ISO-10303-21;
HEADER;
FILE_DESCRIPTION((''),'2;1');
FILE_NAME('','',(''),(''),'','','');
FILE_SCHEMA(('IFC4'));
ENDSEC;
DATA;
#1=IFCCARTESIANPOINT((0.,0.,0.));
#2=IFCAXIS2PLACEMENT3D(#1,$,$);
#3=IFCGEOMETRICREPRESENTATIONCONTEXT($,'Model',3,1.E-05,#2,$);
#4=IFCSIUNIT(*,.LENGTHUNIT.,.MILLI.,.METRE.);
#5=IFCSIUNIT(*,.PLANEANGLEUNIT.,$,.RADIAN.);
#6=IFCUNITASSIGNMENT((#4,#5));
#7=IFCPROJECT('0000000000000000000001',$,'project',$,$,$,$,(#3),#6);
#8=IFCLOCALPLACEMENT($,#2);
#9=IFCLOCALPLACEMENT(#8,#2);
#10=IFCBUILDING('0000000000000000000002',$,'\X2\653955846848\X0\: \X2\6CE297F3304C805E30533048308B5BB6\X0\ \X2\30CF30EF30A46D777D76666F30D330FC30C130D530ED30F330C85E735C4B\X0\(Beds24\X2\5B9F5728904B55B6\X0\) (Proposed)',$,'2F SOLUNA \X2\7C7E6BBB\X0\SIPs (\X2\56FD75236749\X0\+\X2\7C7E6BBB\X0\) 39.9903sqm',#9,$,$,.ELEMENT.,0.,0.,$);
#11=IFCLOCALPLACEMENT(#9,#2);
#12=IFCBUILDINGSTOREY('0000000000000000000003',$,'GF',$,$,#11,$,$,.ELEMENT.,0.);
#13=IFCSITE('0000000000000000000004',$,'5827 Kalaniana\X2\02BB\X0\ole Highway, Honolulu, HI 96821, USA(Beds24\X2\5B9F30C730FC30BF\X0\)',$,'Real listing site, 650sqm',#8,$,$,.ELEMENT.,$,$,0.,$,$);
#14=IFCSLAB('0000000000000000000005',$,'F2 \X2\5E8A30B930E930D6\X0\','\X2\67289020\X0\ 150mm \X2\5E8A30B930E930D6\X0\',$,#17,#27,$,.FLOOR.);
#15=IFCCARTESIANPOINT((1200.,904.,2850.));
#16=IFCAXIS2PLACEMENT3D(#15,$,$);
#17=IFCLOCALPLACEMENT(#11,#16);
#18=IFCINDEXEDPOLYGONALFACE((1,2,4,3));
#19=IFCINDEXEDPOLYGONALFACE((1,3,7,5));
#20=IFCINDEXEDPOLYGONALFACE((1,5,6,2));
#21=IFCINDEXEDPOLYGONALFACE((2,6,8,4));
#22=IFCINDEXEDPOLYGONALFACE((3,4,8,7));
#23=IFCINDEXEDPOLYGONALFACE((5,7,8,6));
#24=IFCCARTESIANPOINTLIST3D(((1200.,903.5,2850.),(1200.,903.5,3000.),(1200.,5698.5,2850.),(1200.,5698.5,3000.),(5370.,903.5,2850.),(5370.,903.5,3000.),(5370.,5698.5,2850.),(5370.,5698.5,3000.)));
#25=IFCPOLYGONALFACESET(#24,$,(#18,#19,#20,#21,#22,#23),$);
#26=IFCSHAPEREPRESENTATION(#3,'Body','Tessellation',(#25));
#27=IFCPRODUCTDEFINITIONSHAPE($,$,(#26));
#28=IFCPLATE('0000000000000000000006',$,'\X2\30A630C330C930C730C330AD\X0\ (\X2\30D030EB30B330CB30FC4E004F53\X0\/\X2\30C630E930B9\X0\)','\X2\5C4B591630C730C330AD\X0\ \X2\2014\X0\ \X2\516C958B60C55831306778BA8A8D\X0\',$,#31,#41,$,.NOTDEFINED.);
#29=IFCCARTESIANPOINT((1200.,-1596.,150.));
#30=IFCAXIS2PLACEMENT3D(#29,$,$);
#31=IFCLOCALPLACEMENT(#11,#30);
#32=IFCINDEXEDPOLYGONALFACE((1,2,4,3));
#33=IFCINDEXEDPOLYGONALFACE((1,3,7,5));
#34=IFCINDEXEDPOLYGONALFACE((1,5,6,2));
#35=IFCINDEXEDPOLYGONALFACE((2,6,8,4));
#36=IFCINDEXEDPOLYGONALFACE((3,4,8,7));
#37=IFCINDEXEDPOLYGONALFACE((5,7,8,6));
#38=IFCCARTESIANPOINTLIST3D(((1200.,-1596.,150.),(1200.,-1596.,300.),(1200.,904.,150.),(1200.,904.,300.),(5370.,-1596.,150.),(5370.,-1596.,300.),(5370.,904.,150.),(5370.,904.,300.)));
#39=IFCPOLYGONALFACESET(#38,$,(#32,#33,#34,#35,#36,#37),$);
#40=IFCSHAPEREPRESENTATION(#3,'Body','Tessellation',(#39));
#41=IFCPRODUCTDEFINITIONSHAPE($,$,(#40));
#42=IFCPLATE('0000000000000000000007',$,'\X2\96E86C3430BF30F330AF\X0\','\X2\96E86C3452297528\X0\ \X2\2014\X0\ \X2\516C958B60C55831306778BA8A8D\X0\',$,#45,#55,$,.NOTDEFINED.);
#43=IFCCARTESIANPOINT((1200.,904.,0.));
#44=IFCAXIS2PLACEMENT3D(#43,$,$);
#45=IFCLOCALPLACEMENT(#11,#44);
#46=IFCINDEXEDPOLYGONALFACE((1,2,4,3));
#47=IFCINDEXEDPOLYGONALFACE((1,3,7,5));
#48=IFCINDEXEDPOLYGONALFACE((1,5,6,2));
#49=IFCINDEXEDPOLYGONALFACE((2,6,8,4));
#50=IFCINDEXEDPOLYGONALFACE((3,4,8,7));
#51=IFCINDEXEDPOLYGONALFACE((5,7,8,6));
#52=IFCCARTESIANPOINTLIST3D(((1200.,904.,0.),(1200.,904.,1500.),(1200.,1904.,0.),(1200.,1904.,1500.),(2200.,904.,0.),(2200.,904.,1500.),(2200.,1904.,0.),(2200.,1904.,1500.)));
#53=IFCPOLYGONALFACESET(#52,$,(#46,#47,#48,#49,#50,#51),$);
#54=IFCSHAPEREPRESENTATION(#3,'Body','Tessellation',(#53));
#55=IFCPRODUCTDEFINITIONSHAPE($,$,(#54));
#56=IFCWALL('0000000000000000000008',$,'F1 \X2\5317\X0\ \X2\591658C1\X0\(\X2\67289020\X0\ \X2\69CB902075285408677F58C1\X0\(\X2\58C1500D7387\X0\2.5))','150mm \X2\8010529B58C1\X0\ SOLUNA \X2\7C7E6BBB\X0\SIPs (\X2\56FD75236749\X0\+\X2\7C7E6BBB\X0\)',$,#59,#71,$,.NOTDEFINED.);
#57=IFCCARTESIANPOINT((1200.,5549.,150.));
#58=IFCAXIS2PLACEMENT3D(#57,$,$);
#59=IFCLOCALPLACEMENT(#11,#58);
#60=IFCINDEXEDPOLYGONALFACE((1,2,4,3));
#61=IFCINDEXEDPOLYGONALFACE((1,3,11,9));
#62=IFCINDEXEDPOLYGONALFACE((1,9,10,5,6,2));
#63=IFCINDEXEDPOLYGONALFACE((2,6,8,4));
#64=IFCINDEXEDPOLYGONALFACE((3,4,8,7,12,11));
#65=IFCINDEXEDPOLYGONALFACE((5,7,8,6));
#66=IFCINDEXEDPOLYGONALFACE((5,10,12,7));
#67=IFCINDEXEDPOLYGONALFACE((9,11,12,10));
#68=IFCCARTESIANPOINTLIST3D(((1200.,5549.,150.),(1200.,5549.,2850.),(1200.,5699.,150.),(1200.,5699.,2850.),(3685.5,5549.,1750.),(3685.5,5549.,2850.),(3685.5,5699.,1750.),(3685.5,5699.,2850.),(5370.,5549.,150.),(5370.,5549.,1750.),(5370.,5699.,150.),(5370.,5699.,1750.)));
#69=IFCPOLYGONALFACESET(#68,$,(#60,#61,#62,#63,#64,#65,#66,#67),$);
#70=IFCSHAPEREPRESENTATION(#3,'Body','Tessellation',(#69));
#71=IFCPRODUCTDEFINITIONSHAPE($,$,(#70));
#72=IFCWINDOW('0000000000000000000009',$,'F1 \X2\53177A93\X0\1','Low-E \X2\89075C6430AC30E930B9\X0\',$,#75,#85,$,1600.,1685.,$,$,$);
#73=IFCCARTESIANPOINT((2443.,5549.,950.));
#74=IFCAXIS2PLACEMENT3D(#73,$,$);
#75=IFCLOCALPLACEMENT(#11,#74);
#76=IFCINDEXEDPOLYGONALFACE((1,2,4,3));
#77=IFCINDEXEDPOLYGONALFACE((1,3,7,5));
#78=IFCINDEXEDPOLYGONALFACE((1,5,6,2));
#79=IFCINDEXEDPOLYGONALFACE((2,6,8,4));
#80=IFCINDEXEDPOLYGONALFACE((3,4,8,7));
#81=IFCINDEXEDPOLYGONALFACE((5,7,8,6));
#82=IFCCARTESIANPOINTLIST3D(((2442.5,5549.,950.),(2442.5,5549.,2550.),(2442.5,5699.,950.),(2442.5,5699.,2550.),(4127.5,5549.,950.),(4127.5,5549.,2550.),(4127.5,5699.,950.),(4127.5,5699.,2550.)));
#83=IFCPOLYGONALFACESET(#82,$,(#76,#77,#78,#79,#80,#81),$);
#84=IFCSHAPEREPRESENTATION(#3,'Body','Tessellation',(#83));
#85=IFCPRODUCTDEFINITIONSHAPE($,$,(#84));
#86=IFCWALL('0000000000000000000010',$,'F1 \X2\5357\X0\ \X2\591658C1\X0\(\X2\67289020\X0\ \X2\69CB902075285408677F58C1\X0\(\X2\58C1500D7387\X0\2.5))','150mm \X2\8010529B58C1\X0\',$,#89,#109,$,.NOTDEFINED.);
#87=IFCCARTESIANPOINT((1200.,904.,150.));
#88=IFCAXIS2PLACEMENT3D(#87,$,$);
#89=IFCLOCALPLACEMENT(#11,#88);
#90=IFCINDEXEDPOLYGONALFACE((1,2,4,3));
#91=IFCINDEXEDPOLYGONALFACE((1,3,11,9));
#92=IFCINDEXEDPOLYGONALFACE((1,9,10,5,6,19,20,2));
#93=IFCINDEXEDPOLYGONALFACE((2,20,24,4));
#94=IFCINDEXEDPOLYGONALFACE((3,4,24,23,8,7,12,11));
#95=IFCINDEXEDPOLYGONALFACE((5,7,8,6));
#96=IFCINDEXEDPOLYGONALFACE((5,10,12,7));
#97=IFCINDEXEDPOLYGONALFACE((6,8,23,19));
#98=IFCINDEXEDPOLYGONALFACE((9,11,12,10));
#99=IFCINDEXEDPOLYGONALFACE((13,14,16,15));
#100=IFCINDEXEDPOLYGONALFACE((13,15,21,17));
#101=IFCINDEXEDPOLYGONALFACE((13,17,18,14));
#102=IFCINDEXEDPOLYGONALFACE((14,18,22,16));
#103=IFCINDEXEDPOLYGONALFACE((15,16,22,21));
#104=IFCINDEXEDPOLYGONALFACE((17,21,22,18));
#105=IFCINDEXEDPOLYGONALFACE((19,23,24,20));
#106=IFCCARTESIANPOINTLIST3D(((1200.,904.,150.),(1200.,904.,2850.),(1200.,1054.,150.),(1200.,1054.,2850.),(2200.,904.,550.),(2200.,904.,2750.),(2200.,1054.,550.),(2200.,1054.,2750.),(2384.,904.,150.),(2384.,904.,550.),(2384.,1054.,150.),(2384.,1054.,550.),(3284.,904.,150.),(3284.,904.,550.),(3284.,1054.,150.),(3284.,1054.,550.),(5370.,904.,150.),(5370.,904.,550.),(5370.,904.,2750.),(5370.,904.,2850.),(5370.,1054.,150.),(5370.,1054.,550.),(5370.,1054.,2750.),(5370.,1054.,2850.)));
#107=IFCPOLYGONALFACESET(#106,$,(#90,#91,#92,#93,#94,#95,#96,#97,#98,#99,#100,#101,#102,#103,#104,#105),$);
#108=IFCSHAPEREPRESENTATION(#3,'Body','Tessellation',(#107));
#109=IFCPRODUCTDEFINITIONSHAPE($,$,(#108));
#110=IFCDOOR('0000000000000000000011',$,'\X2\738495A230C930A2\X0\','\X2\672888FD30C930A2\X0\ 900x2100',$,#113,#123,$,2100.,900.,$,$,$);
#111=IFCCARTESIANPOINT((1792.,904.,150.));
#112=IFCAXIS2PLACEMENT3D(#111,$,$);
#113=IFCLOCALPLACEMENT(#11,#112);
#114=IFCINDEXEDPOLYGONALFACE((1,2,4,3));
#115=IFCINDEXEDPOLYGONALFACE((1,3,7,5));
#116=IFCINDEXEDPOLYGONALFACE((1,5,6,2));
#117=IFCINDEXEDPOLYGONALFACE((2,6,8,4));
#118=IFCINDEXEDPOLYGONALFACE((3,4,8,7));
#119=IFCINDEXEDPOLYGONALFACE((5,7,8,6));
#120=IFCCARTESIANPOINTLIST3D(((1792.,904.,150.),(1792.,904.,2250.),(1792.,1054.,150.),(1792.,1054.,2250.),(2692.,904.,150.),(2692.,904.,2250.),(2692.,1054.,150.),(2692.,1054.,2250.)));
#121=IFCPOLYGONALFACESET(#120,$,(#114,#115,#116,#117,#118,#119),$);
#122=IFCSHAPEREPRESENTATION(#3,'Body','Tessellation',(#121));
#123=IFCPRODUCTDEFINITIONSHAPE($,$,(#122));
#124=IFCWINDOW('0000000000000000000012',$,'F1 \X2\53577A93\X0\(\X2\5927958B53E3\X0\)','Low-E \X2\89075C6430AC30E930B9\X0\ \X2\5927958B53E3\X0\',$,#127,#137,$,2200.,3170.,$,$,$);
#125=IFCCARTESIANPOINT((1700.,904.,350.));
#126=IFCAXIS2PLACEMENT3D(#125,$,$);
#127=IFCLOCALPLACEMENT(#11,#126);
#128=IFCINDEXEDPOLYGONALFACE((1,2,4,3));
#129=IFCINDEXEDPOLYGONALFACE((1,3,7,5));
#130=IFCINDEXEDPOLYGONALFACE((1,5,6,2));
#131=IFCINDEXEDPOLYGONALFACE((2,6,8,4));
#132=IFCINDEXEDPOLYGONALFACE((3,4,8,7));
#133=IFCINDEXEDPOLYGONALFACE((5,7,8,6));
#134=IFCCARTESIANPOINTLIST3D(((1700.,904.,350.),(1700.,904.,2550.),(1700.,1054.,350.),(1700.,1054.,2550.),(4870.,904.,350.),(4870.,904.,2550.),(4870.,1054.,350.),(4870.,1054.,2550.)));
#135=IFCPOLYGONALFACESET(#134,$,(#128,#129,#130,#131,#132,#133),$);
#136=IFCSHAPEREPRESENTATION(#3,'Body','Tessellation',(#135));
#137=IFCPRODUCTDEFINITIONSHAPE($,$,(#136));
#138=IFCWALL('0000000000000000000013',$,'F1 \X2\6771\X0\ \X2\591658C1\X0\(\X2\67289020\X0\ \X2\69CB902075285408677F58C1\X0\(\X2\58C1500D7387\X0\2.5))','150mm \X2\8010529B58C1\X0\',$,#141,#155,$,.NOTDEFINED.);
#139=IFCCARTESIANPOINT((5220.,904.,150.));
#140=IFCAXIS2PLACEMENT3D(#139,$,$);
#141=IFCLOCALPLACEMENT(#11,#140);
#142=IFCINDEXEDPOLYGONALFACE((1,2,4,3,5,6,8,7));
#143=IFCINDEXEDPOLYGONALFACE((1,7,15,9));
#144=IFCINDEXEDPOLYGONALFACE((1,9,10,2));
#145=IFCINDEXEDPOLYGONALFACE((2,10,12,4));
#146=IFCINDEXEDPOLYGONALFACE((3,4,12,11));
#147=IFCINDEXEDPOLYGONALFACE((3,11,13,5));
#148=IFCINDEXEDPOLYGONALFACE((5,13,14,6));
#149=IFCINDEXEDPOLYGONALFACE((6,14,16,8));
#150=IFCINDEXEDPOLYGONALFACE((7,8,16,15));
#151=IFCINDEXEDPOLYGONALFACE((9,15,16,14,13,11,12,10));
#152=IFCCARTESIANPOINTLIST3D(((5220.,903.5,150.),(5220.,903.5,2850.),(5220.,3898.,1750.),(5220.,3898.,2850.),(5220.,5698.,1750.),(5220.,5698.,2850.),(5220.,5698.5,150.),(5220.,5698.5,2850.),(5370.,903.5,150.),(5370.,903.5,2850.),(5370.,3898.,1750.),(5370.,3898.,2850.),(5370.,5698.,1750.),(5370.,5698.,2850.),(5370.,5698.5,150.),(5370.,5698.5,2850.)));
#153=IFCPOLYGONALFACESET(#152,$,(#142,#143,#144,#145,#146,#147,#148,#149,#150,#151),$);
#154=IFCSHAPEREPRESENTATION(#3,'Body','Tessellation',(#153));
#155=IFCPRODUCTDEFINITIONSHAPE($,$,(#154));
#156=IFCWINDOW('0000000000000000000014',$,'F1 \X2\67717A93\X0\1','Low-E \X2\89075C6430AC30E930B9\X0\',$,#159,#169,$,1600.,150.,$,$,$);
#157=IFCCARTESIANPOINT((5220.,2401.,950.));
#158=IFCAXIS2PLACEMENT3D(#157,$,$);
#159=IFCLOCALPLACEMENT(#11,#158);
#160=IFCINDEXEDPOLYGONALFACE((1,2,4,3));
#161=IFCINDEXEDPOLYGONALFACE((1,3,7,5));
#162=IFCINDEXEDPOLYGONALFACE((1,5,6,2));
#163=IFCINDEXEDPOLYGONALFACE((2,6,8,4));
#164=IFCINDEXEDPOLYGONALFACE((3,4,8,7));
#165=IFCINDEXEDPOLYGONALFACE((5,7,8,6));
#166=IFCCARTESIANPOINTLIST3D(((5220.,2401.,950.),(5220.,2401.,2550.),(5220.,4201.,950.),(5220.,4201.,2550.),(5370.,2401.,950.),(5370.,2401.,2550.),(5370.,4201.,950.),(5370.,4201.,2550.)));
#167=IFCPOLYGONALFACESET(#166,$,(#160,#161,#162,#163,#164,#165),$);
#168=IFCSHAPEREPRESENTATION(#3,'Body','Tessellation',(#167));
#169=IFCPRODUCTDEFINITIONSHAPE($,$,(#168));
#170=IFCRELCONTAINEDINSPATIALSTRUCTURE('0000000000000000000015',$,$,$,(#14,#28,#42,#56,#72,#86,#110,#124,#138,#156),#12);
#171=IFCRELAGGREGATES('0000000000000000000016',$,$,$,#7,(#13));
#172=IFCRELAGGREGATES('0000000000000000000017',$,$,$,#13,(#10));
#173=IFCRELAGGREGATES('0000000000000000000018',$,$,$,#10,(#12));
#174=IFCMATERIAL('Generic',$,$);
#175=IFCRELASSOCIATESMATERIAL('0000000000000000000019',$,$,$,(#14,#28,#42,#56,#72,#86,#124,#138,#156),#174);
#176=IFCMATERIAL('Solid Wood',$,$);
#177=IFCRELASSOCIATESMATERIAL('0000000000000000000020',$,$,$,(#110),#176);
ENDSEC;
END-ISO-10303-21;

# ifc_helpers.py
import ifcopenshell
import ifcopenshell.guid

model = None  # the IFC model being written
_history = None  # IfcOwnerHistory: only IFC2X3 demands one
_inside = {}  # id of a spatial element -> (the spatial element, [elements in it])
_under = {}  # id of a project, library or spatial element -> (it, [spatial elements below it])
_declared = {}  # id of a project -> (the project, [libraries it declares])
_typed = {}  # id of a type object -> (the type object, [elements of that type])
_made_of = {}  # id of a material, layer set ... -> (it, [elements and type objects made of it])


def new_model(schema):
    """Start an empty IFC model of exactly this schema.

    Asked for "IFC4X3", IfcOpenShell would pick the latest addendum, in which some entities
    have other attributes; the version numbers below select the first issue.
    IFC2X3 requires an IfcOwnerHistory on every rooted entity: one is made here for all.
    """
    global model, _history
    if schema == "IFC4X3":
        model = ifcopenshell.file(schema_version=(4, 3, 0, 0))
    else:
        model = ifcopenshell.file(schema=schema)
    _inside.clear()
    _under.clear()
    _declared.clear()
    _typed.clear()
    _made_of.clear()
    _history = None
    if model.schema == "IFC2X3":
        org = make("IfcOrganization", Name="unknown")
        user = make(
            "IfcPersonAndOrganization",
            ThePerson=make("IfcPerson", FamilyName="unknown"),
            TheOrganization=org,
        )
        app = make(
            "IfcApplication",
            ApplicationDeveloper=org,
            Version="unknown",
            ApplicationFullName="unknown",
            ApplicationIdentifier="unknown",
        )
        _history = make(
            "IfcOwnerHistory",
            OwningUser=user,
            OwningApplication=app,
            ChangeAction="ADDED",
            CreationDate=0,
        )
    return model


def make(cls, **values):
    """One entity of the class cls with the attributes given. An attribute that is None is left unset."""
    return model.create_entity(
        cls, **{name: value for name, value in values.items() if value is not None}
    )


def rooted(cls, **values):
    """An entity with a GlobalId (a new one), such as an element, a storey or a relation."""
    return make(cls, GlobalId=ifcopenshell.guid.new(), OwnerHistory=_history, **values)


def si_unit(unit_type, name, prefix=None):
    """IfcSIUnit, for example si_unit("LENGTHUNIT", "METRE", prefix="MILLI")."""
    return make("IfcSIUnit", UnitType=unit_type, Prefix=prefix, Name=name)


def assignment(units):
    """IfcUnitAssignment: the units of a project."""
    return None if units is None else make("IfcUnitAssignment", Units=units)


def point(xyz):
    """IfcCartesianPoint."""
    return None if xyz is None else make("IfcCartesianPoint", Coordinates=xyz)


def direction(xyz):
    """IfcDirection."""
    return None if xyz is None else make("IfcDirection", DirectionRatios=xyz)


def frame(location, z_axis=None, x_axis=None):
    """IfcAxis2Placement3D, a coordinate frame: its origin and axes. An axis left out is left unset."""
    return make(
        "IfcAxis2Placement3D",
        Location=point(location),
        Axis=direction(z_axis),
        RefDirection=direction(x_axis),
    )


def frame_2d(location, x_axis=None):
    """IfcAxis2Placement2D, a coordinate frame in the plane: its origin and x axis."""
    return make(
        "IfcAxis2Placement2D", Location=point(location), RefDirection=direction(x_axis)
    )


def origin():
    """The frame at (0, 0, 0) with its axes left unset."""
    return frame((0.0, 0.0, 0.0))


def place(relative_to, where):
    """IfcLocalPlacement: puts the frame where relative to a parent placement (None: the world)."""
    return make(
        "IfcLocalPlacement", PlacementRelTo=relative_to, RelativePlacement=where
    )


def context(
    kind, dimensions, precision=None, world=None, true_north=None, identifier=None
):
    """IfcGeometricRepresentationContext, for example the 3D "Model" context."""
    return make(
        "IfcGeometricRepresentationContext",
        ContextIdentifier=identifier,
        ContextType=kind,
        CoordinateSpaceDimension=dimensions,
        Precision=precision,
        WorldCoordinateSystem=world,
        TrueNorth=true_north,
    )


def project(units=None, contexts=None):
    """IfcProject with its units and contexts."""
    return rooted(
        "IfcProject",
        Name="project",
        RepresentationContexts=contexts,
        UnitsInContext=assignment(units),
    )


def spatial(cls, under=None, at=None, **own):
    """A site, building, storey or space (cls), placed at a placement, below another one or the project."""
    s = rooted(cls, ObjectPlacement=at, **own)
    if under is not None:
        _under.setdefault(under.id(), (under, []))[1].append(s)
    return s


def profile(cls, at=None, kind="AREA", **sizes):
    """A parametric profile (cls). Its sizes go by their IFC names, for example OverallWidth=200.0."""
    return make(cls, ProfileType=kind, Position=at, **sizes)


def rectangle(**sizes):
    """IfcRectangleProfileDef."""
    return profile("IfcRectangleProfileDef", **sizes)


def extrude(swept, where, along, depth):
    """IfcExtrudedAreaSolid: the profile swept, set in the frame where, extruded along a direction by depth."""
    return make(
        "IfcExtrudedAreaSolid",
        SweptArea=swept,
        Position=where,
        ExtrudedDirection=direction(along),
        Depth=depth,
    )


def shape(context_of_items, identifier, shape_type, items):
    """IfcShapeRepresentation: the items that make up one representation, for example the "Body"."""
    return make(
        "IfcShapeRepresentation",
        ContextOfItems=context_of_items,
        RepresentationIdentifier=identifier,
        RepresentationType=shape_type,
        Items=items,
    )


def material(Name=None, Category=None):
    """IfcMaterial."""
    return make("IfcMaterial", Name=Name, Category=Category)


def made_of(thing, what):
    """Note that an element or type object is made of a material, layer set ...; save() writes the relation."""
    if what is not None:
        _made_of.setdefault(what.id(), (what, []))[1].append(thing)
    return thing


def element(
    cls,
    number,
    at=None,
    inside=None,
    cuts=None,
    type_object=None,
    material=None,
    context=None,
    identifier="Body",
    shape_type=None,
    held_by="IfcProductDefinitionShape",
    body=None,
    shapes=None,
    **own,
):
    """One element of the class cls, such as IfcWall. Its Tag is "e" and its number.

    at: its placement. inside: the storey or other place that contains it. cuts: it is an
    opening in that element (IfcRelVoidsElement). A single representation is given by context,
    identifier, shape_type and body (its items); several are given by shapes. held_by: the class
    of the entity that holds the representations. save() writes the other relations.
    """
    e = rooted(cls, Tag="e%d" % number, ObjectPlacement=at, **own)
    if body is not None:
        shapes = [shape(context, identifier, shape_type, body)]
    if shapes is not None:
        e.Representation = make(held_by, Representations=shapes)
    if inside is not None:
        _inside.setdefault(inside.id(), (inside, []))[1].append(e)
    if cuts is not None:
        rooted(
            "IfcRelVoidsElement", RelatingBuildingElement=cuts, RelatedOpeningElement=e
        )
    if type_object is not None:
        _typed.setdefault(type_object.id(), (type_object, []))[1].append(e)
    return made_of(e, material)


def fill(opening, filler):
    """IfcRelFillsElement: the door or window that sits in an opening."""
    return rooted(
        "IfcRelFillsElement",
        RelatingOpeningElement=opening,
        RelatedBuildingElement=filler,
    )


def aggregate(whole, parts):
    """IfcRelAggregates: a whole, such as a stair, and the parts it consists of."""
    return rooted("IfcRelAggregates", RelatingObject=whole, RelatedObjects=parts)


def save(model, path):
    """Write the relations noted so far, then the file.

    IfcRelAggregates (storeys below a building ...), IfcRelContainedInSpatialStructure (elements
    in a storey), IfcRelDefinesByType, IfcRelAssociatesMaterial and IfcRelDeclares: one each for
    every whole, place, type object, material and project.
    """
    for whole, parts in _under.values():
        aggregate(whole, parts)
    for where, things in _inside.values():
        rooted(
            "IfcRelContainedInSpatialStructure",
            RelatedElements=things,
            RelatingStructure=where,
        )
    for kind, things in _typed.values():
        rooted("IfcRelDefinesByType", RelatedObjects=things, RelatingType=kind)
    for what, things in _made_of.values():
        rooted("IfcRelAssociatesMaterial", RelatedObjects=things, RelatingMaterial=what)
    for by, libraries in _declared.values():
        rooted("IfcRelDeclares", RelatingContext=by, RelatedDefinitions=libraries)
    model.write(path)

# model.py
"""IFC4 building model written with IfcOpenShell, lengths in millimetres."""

from ifc_helpers import new_model, si_unit, frame, frame_2d, origin, place, context, project, spatial, rectangle, extrude, material, element, fill, save


model = new_model("IFC4")

# Units and contexts
model_context = context("Model", 3, precision=1e-05, world=origin())
ifc_project = project(units=[si_unit("LENGTHUNIT", "METRE", prefix="MILLI"), si_unit("PLANEANGLEUNIT", "RADIAN")], contexts=[model_context])

# Site, building, storey
site_placement = place(None, origin())
site = spatial("IfcSite", under=ifc_project, at=site_placement, Name="5827 Kalanianaʻole Highway, Honolulu, HI 96821, USA(Beds24実データ)", ObjectType="Real listing site, 650sqm", CompositionType="ELEMENT", RefElevation=0.0)
building_placement = place(site_placement, origin())
building = spatial("IfcBuilding", under=site, at=building_placement, Name="改善案: 波音が聞こえる家 ハワイ海絶景ビーチフロント平屋(Beds24実在運営) (Proposed)", ObjectType="2F SOLUNA 籾殻SIPs (国産杉+籾殻) 39.9903sqm", CompositionType="ELEMENT", ElevationOfRefHeight=0.0, ElevationOfTerrain=0.0)
storey_placement = place(building_placement, origin())
storey = spatial("IfcBuildingStorey", under=building, at=storey_placement, Name="GF", CompositionType="ELEMENT", Elevation=0.0)

# Slab
ifc_material_1 = material(Name="Generic")
slab_1_placement = place(storey_placement, frame((1200.0, 904.0, 2850.0)))
element("IfcSlab", 1, at=slab_1_placement, inside=storey, material=ifc_material_1, Name="F2 床スラブ", Description="木造 150mm 床スラブ", PredefinedType="FLOOR", context=model_context, shape_type="SweptSolid", body=[
    extrude(rectangle(XDim=4170.0, YDim=4795.0, at=frame_2d((2085.0, 2397.0))), frame((1200.0, 904.0, 2850.0)), (0.0, 0.0, 1.0), 150.0),
])

# Plates
plate_1_placement = place(storey_placement, frame((1200.0, -1596.0, 150.0)))
element("IfcPlate", 2, at=plate_1_placement, inside=storey, material=ifc_material_1, Name="ウッドデッキ (バルコニー一体/テラス)", Description="屋外デッキ — 公開情報で確認", PredefinedType="NOTDEFINED", context=model_context, shape_type="SweptSolid", body=[
    extrude(rectangle(XDim=4170.0, YDim=2500.0, at=frame_2d((2085.0, 1250.0))), frame((1200.0, -1596.0, 150.0)), (0.0, 0.0, 1.0), 150.0),
])
plate_2_placement = place(storey_placement, frame((1200.0, 904.0, 0.0)))
element("IfcPlate", 3, at=plate_2_placement, inside=storey, material=ifc_material_1, Name="雨水タンク", Description="雨水利用 — 公開情報で確認", PredefinedType="NOTDEFINED", context=model_context, shape_type="SweptSolid", body=[
    extrude(rectangle(XDim=1000.0, YDim=1000.0, at=frame_2d((500.0, 500.0))), frame((1200.0, 904.0, 0.0)), (0.0, 0.0, 1.0), 1500.0),
])

# Wall, opening, window
wall_1_placement = place(storey_placement, frame((1200.0, 5549.0, 150.0)))
wall_1 = element("IfcWall", 4, at=wall_1_placement, inside=storey, material=ifc_material_1, Name="F1 北 外壁(木造 構造用合板壁(壁倍率2.5))", Description="150mm 耐力壁 SOLUNA 籾殻SIPs (国産杉+籾殻)", PredefinedType="NOTDEFINED", context=model_context, shape_type="SweptSolid", body=[
    extrude(rectangle(XDim=4170.0, YDim=150.0, at=frame_2d((2085.0, 75.0))), frame((1200.0, 5549.0, 150.0)), (0.0, 0.0, 1.0), 2700.0),
])
opening_1_placement = place(storey_placement, frame((2443.0, 5549.0, 950.0)))
opening_1 = element("IfcOpeningElement", 5, at=opening_1_placement, cuts=wall_1, PredefinedType="NOTDEFINED", context=model_context, shape_type="SweptSolid", body=[
    extrude(rectangle(XDim=1685.0, YDim=150.0, at=frame_2d((842.0, 75.0))), frame((2443.0, 5549.0, 950.0)), (0.0, 0.0, 1.0), 1600.0),
])
window_1_placement = place(storey_placement, frame((2443.0, 5549.0, 950.0)))
window_1 = element("IfcWindow", 6, at=window_1_placement, inside=storey, material=ifc_material_1, Name="F1 北窓1", Description="Low-E 複層ガラス", OverallHeight=1600.0, OverallWidth=1685.0, context=model_context, shape_type="SweptSolid", body=[
    extrude(rectangle(XDim=1685.0, YDim=150.0, at=frame_2d((842.0, 75.0))), frame((2443.0, 5549.0, 950.0)), (0.0, 0.0, 1.0), 1600.0),
])
fill(opening_1, window_1)

# Wall, openings, door, window
wall_2_placement = place(storey_placement, frame((1200.0, 904.0, 150.0)))
wall_2 = element("IfcWall", 7, at=wall_2_placement, inside=storey, material=ifc_material_1, Name="F1 南 外壁(木造 構造用合板壁(壁倍率2.5))", Description="150mm 耐力壁", PredefinedType="NOTDEFINED", context=model_context, shape_type="SweptSolid", body=[
    extrude(rectangle(XDim=4170.0, YDim=150.0, at=frame_2d((2085.0, 75.0))), frame((1200.0, 904.0, 150.0)), (0.0, 0.0, 1.0), 2700.0),
])
opening_2_placement = place(storey_placement, frame((1792.0, 904.0, 150.0)))
opening_2 = element("IfcOpeningElement", 8, at=opening_2_placement, cuts=wall_2, PredefinedType="NOTDEFINED", context=model_context, shape_type="SweptSolid", body=[
    extrude(rectangle(XDim=900.0, YDim=150.0, at=frame_2d((450.0, 75.0))), frame((1792.0, 904.0, 150.0)), (0.0, 0.0, 1.0), 2100.0),
])
opening_3_placement = place(storey_placement, frame((1700.0, 904.0, 350.0)))
opening_3 = element("IfcOpeningElement", 9, at=opening_3_placement, cuts=wall_2, PredefinedType="NOTDEFINED", context=model_context, shape_type="SweptSolid", body=[
    extrude(rectangle(XDim=3170.0, YDim=150.0, at=frame_2d((1585.0, 75.0))), frame((1700.0, 904.0, 350.0)), (0.0, 0.0, 1.0), 2200.0),
])
ifc_material_2 = material(Name="Solid Wood")
door_placement = place(storey_placement, frame((1792.0, 904.0, 150.0)))
door = element("IfcDoor", 10, at=door_placement, inside=storey, material=ifc_material_2, Name="玄関ドア", Description="木製ドア 900x2100", OverallHeight=2100.0, OverallWidth=900.0, context=model_context, shape_type="SweptSolid", body=[
    extrude(rectangle(XDim=900.0, YDim=150.0, at=frame_2d((450.0, 75.0))), frame((1792.0, 904.0, 150.0)), (0.0, 0.0, 1.0), 2100.0),
])
fill(opening_2, door)
window_2_placement = place(storey_placement, frame((1700.0, 904.0, 350.0)))
window_2 = element("IfcWindow", 11, at=window_2_placement, inside=storey, material=ifc_material_1, Name="F1 南窓(大開口)", Description="Low-E 複層ガラス 大開口", OverallHeight=2200.0, OverallWidth=3170.0, context=model_context, shape_type="SweptSolid", body=[
    extrude(rectangle(XDim=3170.0, YDim=150.0, at=frame_2d((1585.0, 75.0))), frame((1700.0, 904.0, 350.0)), (0.0, 0.0, 1.0), 2200.0),
])
fill(opening_3, window_2)

# Wall, opening, window
wall_3_placement = place(storey_placement, frame((5220.0, 904.0, 150.0)))
wall_3 = element("IfcWall", 12, at=wall_3_placement, inside=storey, material=ifc_material_1, Name="F1 東 外壁(木造 構造用合板壁(壁倍率2.5))", Description="150mm 耐力壁", PredefinedType="NOTDEFINED", context=model_context, shape_type="SweptSolid", body=[
    extrude(rectangle(XDim=150.0, YDim=4795.0, at=frame_2d((75.0, 2397.0))), frame((5220.0, 904.0, 150.0)), (0.0, 0.0, 1.0), 2700.0),
])
opening_4_placement = place(storey_placement, frame((5220.0, 2401.0, 950.0)))
opening_4 = element("IfcOpeningElement", 13, at=opening_4_placement, cuts=wall_3, PredefinedType="NOTDEFINED", context=model_context, shape_type="SweptSolid", body=[
    extrude(rectangle(XDim=150.0, YDim=1800.0, at=frame_2d((75.0, 900.0))), frame((5220.0, 2401.0, 950.0)), (0.0, 0.0, 1.0), 1600.0),
])
window_3_placement = place(storey_placement, frame((5220.0, 2401.0, 950.0)))
window_3 = element("IfcWindow", 14, at=window_3_placement, inside=storey, material=ifc_material_1, Name="F1 東窓1", Description="Low-E 複層ガラス", OverallHeight=1600.0, OverallWidth=150.0, context=model_context, shape_type="SweptSolid", body=[
    extrude(rectangle(XDim=150.0, YDim=1800.0, at=frame_2d((75.0, 900.0))), frame((5220.0, 2401.0, 950.0)), (0.0, 0.0, 1.0), 1600.0),
])
fill(opening_4, window_3)

save(model, "model.ifc")
